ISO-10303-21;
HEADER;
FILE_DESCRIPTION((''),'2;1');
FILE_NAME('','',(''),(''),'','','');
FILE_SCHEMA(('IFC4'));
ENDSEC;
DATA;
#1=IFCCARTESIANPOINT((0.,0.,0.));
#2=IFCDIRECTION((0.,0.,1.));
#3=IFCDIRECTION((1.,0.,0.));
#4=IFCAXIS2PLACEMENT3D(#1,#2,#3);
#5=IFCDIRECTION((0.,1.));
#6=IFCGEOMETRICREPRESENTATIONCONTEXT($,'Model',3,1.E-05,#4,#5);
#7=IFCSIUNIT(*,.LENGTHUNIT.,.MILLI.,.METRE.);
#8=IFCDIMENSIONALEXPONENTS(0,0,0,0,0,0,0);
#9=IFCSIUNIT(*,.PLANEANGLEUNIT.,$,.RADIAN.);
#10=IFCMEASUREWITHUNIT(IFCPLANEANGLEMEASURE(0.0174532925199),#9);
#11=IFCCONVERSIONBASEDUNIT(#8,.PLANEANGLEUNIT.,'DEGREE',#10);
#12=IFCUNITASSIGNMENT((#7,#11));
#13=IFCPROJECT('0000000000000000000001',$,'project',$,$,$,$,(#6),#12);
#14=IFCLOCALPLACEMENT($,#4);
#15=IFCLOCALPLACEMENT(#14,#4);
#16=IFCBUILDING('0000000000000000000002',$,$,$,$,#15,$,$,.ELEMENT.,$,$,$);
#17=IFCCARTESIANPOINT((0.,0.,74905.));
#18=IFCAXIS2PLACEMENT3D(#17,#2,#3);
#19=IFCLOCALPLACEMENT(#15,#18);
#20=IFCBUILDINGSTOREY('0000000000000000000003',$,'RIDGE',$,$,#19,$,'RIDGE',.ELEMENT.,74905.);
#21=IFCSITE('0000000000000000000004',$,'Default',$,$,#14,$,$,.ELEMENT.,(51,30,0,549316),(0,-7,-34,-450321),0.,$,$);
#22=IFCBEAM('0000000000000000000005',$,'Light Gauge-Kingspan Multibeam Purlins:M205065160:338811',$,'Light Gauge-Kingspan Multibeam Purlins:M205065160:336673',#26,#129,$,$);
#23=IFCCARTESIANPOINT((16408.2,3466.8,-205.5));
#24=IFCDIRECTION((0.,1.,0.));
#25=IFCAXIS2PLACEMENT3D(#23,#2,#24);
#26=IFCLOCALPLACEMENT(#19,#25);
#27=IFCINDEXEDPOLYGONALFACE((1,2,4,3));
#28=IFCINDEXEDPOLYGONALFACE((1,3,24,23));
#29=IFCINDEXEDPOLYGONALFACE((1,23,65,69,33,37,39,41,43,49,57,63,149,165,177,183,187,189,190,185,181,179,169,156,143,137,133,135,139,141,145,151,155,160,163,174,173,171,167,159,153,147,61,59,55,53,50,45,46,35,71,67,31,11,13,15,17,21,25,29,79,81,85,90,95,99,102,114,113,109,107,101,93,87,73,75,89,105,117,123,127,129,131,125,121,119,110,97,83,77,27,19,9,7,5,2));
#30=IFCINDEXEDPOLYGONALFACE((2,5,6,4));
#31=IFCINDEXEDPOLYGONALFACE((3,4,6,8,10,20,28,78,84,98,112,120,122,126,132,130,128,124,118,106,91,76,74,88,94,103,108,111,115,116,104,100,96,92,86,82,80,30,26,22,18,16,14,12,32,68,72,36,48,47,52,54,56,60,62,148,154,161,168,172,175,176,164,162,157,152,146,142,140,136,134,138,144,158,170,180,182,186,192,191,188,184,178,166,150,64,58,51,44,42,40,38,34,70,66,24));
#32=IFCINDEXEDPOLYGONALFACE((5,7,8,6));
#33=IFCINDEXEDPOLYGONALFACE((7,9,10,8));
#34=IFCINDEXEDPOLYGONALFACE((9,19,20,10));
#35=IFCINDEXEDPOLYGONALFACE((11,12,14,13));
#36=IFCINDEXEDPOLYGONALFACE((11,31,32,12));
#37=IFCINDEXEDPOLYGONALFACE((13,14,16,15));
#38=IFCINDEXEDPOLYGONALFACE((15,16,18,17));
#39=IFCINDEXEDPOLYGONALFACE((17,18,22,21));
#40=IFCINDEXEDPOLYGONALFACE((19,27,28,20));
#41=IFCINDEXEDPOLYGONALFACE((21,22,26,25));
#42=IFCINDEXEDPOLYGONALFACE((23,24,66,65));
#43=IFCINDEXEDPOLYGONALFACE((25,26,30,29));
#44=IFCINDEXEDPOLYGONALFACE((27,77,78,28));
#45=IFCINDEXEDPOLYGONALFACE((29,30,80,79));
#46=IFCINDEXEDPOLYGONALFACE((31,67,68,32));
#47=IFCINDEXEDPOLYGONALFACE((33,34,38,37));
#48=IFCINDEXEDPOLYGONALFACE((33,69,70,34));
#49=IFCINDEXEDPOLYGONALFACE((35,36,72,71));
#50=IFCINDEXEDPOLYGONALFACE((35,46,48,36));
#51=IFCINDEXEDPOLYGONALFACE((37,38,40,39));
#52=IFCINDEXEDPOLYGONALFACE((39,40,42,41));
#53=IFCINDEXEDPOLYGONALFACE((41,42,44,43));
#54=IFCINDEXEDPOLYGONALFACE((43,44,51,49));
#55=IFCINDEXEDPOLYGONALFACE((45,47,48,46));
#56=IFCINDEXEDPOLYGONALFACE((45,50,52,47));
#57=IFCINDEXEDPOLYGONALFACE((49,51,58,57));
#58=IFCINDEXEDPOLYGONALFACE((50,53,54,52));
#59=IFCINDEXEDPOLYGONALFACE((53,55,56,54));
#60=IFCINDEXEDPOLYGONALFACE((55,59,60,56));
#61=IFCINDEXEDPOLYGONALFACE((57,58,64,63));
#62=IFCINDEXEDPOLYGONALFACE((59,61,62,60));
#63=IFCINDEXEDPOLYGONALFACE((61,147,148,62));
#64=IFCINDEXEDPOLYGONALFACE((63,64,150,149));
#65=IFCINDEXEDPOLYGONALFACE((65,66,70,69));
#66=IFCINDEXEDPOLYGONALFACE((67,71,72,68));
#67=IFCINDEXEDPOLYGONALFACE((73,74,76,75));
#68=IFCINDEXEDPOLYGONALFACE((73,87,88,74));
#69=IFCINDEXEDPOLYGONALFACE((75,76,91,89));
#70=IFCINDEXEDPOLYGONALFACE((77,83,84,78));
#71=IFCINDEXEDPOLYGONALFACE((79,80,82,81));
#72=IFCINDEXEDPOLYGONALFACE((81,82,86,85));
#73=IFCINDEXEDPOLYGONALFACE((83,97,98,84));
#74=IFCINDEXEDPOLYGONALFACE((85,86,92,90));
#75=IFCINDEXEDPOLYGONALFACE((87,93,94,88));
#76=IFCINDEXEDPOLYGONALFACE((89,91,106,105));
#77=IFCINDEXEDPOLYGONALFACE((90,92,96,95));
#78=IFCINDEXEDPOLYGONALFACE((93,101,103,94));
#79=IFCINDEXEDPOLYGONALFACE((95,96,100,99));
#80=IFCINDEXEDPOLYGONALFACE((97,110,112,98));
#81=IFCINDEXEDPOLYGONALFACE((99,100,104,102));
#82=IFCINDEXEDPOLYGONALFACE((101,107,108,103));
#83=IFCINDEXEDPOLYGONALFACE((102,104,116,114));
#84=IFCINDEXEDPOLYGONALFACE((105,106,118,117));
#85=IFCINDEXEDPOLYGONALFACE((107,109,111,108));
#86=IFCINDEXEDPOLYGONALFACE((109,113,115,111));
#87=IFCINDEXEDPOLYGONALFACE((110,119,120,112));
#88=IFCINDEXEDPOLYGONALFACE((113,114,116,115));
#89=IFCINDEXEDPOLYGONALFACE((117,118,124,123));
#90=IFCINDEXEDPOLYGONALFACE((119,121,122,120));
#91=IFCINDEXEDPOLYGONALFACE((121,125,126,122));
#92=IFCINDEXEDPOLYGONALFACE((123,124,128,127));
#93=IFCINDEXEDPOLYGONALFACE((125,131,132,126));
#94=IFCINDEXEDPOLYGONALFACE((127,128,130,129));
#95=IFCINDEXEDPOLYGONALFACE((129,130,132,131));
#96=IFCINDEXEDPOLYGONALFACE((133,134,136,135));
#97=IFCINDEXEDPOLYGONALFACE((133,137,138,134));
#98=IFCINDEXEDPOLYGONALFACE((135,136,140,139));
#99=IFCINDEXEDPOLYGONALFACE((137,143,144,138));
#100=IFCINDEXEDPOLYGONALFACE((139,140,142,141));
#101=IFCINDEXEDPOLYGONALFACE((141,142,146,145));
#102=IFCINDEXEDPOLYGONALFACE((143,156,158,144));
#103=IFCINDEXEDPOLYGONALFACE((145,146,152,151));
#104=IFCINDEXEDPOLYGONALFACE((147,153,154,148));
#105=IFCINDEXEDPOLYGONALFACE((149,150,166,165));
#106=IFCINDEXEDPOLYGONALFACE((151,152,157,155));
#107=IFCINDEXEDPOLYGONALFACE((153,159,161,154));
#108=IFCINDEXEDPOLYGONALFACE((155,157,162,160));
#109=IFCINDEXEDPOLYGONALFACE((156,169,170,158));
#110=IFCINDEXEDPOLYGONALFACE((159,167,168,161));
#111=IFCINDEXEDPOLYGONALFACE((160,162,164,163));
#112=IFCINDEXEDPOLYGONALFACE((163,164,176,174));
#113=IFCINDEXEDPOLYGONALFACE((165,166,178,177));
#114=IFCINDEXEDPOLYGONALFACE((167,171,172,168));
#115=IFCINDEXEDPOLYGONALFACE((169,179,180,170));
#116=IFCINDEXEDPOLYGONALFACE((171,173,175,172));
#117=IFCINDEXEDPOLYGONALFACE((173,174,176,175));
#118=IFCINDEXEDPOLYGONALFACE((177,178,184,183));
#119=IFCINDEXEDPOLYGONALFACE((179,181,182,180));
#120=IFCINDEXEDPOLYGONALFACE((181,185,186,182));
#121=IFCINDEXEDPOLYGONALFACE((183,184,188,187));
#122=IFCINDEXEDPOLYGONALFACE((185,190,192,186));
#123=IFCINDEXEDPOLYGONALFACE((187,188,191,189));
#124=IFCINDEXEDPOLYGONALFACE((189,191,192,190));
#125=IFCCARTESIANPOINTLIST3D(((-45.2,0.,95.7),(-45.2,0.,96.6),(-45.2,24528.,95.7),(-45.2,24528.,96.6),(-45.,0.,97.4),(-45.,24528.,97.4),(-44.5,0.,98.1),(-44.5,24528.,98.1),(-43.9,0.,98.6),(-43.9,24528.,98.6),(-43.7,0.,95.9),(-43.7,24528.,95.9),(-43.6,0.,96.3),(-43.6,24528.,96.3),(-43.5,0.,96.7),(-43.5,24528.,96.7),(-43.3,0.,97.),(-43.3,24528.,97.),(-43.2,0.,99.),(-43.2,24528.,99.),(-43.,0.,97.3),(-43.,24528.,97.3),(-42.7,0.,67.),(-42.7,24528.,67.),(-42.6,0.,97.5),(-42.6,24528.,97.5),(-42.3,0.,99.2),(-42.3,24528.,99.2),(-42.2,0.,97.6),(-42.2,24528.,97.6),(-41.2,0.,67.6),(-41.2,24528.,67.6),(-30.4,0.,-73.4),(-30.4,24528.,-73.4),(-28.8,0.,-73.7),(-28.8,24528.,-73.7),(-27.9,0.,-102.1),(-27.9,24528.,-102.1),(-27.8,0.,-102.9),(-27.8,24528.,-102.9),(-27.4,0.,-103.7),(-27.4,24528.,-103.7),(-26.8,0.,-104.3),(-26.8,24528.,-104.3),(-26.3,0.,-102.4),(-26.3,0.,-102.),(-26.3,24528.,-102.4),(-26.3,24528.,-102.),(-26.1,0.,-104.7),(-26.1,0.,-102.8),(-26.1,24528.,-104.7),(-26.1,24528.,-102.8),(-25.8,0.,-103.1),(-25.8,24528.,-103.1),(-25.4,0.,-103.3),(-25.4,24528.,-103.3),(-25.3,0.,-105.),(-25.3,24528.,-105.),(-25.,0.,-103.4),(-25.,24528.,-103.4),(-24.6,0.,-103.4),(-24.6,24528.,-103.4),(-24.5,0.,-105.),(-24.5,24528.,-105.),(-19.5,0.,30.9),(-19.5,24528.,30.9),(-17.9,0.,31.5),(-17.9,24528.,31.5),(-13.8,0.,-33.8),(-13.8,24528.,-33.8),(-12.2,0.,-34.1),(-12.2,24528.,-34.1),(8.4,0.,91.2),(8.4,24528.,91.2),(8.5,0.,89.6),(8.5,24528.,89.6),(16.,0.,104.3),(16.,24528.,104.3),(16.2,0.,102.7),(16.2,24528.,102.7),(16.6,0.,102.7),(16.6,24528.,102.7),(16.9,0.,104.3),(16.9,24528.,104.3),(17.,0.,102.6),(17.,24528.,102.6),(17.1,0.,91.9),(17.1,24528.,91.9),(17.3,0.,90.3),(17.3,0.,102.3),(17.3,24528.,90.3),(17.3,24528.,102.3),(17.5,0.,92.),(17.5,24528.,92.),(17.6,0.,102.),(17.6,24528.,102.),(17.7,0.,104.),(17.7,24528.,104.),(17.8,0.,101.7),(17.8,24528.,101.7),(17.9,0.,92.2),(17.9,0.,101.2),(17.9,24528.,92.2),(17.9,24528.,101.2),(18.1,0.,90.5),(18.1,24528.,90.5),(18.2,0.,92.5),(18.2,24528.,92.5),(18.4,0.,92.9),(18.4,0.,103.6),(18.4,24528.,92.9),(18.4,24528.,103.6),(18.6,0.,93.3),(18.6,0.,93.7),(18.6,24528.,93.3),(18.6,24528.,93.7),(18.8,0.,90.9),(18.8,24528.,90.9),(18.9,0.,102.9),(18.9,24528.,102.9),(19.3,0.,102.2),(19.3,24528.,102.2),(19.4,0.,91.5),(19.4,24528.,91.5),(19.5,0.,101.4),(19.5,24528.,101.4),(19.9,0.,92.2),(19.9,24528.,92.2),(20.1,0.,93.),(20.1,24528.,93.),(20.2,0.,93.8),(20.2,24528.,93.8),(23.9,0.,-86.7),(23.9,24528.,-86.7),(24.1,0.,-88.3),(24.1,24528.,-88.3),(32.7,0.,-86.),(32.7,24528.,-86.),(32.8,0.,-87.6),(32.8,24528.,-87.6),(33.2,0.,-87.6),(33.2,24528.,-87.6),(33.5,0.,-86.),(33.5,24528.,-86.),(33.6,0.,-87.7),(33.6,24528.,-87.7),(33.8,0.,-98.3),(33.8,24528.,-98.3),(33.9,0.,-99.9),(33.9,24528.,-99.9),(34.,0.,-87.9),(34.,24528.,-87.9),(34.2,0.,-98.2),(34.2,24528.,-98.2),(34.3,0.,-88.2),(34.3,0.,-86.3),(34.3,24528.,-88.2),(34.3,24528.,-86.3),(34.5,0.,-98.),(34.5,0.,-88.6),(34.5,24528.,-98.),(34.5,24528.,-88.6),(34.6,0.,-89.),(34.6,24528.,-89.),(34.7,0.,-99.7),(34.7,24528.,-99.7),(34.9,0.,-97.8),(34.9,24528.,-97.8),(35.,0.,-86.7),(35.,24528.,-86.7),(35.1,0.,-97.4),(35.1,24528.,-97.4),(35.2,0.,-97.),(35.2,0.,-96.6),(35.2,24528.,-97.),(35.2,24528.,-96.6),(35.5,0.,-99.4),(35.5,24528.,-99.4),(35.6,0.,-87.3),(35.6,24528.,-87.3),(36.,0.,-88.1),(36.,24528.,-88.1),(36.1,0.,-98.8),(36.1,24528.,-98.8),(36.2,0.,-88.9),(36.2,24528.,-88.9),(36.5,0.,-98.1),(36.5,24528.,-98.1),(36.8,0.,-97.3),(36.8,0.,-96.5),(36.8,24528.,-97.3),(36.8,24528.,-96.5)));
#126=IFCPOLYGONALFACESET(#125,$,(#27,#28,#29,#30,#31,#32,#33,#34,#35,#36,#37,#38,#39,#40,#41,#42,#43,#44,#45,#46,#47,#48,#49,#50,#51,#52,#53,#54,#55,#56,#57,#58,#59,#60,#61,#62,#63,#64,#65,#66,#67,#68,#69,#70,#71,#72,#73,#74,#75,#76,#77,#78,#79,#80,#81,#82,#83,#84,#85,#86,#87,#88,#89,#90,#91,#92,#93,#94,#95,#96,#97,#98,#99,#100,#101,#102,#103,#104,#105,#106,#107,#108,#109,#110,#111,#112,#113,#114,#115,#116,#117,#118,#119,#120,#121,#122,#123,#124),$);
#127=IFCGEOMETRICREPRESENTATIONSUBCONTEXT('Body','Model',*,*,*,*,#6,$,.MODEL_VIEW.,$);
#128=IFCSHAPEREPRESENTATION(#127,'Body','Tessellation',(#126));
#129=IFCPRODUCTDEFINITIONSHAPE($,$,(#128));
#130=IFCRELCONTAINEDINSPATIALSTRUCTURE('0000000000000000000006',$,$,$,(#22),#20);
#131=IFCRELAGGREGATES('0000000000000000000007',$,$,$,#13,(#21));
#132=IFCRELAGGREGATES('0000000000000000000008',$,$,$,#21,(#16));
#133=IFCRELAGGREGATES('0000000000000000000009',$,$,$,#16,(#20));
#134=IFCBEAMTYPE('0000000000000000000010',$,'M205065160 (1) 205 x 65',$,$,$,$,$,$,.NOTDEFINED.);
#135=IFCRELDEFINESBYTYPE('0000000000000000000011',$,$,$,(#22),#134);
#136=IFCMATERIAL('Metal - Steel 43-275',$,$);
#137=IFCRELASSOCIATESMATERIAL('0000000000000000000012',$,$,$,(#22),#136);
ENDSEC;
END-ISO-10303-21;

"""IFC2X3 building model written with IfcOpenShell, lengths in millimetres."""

from ifc_helpers import new_model, entity, si_unit, converted_unit, point, direction, frame, frame_2d, origin_with_axes, place, context, subcontext, project, spatial, polyline, circle_curve, parameter, trimmed, segment, composite_curve, outline, extrude, material, type_object, element, save


model = new_model("IFC2X3")

# Units and contexts
model_context = context("Model", 3, precision=1e-05, world=origin_with_axes(), true_north=direction((0.0, 1.0)))
body_context = subcontext(model_context, "Body", "Model", "MODEL_VIEW")
ifc_project = project(units=[si_unit("LENGTHUNIT", "METRE", prefix="MILLI"), converted_unit("PLANEANGLEUNIT", "DEGREE", entity("IfcPlaneAngleMeasure", 0.0174532925199), si_unit("PLANEANGLEUNIT", "RADIAN"), dimensions=[0, 0, 0, 0, 0, 0, 0])], contexts=[model_context])

# Site, building, storey
site_placement = place(None, origin_with_axes())
site = spatial("IfcSite", under=ifc_project, at=site_placement, Name="Default", CompositionType="ELEMENT", RefLatitude=(51, 30, 0, 549316), RefLongitude=(0, -7, -34, -450321), RefElevation=0.0)
building_placement = place(site_placement, origin_with_axes())
building = spatial("IfcBuilding", under=site, at=building_placement, CompositionType="ELEMENT")
storey_placement = place(building_placement, frame((0.0, 0.0, 74905.0), z_axis=(0.0, 0.0, 1.0), x_axis=(1.0, 0.0, 0.0)))
storey = spatial("IfcBuildingStorey", under=building, at=storey_placement, Name="RIDGE", LongName="RIDGE", CompositionType="ELEMENT", Elevation=74905.0)

# Beam
ifc_material_1 = material(Name="Metal - Steel 43-275")
beam_type_1 = type_object("IfcBeamType", Name="M205065160 (1) 205 x 65", PredefinedType="NOTDEFINED")
beam_1_placement = place(storey_placement, frame((16408.2, 3466.8, -205.5), z_axis=(0.0, 0.0, 1.0), x_axis=(0.0, 1.0, 0.0)))
element("IfcBeam", 1, at=beam_1_placement, inside=storey, type_object=beam_type_1, material=ifc_material_1, Name="Light Gauge-Kingspan Multibeam Purlins:M205065160:338811", ObjectType="Light Gauge-Kingspan Multibeam Purlins:M205065160:336673", context=body_context, shape_type="SweptSolid", body=[
    extrude(outline(composite_curve([segment(polyline([(91.7, -28.3), (99.3, -28.3)]), True, "CONTINUOUS"), segment(trimmed(circle_curve(frame_2d((99.3, -25.1), x_axis=(0.0, -1.0)), 3.2), [point((99.3, -28.3)), parameter(0.0)], [point((102.5, -25.1)), parameter(90.0)], True, "CARTESIAN"), True, "CONTINUOUS"), segment(polyline([(102.5, -25.1), (102.5, 33.5)]), True, "CONTINUOUS"), segment(trimmed(circle_curve(frame_2d((99.3, 33.5), x_axis=(1.0, 0.0)), 3.2), [point((102.5, 33.5)), parameter(0.0)], [point((99.3, 36.7)), parameter(90.0)], True, "CARTESIAN"), True, "CONTINUOUS"), segment(polyline([(99.3, 36.7), (70.5, 36.7), (32.5, 16.7), (-32.5, 16.7), (-70.5, 36.7), (-99.3, 36.7)]), True, "CONTINUOUS"), segment(trimmed(circle_curve(frame_2d((-99.3, 33.5), x_axis=(0.0, 1.0)), 3.2), [point((-99.3, 36.7)), parameter(0.0)], [point((-102.5, 33.5)), parameter(90.0)], True, "CARTESIAN"), True, "CONTINUOUS"), segment(polyline([(-102.5, 33.5), (-102.5, -25.1)]), True, "CONTINUOUS"), segment(trimmed(circle_curve(frame_2d((-99.3, -25.1), x_axis=(-1.0, 0.0)), 3.2), [point((-102.5, -25.1)), parameter(0.0)], [point((-99.3, -28.3)), parameter(90.0)], True, "CARTESIAN"), True, "CONTINUOUS"), segment(polyline([(-99.3, -28.3), (-91.7, -28.3)]), True, "CONTINUOUS"), segment(trimmed(circle_curve(frame_2d((-91.7, -25.1), x_axis=(0.0, -1.0)), 3.2), [point((-91.7, -28.3)), parameter(0.0)], [point((-88.5, -25.1)), parameter(90.0)], True, "CARTESIAN"), True, "CONTINUOUS"), segment(polyline([(-88.5, -25.1), (-88.5, -16.3), (-90.1, -16.3), (-90.1, -25.1)]), True, "CONTINUOUS"), segment(trimmed(circle_curve(frame_2d((-91.7, -25.1), x_axis=(0.0, -1.0)), 1.6), [point((-90.1, -25.1)), parameter(90.0)], [point((-91.7, -26.7)), parameter(0.0)], False, "CARTESIAN"), True, "CONTINUOUS"), segment(polyline([(-91.7, -26.7), (-99.3, -26.7)]), True, "CONTINUOUS"), segment(trimmed(circle_curve(frame_2d((-99.3, -25.1), x_axis=(-1.0, 0.0)), 1.6), [point((-99.3, -26.7)), parameter(90.0)], [point((-100.9, -25.1)), parameter(0.0)], False, "CARTESIAN"), True, "CONTINUOUS"), segment(polyline([(-100.9, -25.1), (-100.9, 33.5)]), True, "CONTINUOUS"), segment(trimmed(circle_curve(frame_2d((-99.3, 33.5), x_axis=(0.0, 1.0)), 1.6), [point((-100.9, 33.5)), parameter(90.0)], [point((-99.3, 35.1)), parameter(0.0)], False, "CARTESIAN"), True, "CONTINUOUS"), segment(polyline([(-99.3, 35.1), (-70.9, 35.1), (-32.9, 15.1), (32.9, 15.1), (70.9, 35.1), (99.3, 35.1)]), True, "CONTINUOUS"), segment(trimmed(circle_curve(frame_2d((99.3, 33.5), x_axis=(1.0, 0.0)), 1.6), [point((99.3, 35.1)), parameter(90.0)], [point((100.9, 33.5)), parameter(0.0)], False, "CARTESIAN"), True, "CONTINUOUS"), segment(polyline([(100.9, 33.5), (100.9, -25.1)]), True, "CONTINUOUS"), segment(trimmed(circle_curve(frame_2d((99.3, -25.1), x_axis=(0.0, -1.0)), 1.6), [point((100.9, -25.1)), parameter(90.0)], [point((99.3, -26.7)), parameter(0.0)], False, "CARTESIAN"), True, "CONTINUOUS"), segment(polyline([(99.3, -26.7), (91.7, -26.7)]), True, "CONTINUOUS"), segment(trimmed(circle_curve(frame_2d((91.7, -25.1), x_axis=(-1.0, 0.0)), 1.6), [point((91.7, -26.7)), parameter(90.0)], [point((90.1, -25.1)), parameter(0.0)], False, "CARTESIAN"), True, "CONTINUOUS"), segment(polyline([(90.1, -25.1), (90.1, -16.3), (88.5, -16.3), (88.5, -25.1)]), True, "CONTINUOUS"), segment(trimmed(circle_curve(frame_2d((91.7, -25.1), x_axis=(-1.0, 0.0)), 3.2), [point((88.5, -25.1)), parameter(0.0)], [point((91.7, -28.3)), parameter(90.0)], True, "CARTESIAN"), True, "CONTINUOUS")], self_intersect=False)), frame((0.0, 24528.0, 0.0), z_axis=(0.0, -1.0, 0.0), x_axis=(-0.087156, 0.0, 0.996195)), (0.0, 0.0, 1.0), 24528.0),
])

save(model, "model.ifc")
